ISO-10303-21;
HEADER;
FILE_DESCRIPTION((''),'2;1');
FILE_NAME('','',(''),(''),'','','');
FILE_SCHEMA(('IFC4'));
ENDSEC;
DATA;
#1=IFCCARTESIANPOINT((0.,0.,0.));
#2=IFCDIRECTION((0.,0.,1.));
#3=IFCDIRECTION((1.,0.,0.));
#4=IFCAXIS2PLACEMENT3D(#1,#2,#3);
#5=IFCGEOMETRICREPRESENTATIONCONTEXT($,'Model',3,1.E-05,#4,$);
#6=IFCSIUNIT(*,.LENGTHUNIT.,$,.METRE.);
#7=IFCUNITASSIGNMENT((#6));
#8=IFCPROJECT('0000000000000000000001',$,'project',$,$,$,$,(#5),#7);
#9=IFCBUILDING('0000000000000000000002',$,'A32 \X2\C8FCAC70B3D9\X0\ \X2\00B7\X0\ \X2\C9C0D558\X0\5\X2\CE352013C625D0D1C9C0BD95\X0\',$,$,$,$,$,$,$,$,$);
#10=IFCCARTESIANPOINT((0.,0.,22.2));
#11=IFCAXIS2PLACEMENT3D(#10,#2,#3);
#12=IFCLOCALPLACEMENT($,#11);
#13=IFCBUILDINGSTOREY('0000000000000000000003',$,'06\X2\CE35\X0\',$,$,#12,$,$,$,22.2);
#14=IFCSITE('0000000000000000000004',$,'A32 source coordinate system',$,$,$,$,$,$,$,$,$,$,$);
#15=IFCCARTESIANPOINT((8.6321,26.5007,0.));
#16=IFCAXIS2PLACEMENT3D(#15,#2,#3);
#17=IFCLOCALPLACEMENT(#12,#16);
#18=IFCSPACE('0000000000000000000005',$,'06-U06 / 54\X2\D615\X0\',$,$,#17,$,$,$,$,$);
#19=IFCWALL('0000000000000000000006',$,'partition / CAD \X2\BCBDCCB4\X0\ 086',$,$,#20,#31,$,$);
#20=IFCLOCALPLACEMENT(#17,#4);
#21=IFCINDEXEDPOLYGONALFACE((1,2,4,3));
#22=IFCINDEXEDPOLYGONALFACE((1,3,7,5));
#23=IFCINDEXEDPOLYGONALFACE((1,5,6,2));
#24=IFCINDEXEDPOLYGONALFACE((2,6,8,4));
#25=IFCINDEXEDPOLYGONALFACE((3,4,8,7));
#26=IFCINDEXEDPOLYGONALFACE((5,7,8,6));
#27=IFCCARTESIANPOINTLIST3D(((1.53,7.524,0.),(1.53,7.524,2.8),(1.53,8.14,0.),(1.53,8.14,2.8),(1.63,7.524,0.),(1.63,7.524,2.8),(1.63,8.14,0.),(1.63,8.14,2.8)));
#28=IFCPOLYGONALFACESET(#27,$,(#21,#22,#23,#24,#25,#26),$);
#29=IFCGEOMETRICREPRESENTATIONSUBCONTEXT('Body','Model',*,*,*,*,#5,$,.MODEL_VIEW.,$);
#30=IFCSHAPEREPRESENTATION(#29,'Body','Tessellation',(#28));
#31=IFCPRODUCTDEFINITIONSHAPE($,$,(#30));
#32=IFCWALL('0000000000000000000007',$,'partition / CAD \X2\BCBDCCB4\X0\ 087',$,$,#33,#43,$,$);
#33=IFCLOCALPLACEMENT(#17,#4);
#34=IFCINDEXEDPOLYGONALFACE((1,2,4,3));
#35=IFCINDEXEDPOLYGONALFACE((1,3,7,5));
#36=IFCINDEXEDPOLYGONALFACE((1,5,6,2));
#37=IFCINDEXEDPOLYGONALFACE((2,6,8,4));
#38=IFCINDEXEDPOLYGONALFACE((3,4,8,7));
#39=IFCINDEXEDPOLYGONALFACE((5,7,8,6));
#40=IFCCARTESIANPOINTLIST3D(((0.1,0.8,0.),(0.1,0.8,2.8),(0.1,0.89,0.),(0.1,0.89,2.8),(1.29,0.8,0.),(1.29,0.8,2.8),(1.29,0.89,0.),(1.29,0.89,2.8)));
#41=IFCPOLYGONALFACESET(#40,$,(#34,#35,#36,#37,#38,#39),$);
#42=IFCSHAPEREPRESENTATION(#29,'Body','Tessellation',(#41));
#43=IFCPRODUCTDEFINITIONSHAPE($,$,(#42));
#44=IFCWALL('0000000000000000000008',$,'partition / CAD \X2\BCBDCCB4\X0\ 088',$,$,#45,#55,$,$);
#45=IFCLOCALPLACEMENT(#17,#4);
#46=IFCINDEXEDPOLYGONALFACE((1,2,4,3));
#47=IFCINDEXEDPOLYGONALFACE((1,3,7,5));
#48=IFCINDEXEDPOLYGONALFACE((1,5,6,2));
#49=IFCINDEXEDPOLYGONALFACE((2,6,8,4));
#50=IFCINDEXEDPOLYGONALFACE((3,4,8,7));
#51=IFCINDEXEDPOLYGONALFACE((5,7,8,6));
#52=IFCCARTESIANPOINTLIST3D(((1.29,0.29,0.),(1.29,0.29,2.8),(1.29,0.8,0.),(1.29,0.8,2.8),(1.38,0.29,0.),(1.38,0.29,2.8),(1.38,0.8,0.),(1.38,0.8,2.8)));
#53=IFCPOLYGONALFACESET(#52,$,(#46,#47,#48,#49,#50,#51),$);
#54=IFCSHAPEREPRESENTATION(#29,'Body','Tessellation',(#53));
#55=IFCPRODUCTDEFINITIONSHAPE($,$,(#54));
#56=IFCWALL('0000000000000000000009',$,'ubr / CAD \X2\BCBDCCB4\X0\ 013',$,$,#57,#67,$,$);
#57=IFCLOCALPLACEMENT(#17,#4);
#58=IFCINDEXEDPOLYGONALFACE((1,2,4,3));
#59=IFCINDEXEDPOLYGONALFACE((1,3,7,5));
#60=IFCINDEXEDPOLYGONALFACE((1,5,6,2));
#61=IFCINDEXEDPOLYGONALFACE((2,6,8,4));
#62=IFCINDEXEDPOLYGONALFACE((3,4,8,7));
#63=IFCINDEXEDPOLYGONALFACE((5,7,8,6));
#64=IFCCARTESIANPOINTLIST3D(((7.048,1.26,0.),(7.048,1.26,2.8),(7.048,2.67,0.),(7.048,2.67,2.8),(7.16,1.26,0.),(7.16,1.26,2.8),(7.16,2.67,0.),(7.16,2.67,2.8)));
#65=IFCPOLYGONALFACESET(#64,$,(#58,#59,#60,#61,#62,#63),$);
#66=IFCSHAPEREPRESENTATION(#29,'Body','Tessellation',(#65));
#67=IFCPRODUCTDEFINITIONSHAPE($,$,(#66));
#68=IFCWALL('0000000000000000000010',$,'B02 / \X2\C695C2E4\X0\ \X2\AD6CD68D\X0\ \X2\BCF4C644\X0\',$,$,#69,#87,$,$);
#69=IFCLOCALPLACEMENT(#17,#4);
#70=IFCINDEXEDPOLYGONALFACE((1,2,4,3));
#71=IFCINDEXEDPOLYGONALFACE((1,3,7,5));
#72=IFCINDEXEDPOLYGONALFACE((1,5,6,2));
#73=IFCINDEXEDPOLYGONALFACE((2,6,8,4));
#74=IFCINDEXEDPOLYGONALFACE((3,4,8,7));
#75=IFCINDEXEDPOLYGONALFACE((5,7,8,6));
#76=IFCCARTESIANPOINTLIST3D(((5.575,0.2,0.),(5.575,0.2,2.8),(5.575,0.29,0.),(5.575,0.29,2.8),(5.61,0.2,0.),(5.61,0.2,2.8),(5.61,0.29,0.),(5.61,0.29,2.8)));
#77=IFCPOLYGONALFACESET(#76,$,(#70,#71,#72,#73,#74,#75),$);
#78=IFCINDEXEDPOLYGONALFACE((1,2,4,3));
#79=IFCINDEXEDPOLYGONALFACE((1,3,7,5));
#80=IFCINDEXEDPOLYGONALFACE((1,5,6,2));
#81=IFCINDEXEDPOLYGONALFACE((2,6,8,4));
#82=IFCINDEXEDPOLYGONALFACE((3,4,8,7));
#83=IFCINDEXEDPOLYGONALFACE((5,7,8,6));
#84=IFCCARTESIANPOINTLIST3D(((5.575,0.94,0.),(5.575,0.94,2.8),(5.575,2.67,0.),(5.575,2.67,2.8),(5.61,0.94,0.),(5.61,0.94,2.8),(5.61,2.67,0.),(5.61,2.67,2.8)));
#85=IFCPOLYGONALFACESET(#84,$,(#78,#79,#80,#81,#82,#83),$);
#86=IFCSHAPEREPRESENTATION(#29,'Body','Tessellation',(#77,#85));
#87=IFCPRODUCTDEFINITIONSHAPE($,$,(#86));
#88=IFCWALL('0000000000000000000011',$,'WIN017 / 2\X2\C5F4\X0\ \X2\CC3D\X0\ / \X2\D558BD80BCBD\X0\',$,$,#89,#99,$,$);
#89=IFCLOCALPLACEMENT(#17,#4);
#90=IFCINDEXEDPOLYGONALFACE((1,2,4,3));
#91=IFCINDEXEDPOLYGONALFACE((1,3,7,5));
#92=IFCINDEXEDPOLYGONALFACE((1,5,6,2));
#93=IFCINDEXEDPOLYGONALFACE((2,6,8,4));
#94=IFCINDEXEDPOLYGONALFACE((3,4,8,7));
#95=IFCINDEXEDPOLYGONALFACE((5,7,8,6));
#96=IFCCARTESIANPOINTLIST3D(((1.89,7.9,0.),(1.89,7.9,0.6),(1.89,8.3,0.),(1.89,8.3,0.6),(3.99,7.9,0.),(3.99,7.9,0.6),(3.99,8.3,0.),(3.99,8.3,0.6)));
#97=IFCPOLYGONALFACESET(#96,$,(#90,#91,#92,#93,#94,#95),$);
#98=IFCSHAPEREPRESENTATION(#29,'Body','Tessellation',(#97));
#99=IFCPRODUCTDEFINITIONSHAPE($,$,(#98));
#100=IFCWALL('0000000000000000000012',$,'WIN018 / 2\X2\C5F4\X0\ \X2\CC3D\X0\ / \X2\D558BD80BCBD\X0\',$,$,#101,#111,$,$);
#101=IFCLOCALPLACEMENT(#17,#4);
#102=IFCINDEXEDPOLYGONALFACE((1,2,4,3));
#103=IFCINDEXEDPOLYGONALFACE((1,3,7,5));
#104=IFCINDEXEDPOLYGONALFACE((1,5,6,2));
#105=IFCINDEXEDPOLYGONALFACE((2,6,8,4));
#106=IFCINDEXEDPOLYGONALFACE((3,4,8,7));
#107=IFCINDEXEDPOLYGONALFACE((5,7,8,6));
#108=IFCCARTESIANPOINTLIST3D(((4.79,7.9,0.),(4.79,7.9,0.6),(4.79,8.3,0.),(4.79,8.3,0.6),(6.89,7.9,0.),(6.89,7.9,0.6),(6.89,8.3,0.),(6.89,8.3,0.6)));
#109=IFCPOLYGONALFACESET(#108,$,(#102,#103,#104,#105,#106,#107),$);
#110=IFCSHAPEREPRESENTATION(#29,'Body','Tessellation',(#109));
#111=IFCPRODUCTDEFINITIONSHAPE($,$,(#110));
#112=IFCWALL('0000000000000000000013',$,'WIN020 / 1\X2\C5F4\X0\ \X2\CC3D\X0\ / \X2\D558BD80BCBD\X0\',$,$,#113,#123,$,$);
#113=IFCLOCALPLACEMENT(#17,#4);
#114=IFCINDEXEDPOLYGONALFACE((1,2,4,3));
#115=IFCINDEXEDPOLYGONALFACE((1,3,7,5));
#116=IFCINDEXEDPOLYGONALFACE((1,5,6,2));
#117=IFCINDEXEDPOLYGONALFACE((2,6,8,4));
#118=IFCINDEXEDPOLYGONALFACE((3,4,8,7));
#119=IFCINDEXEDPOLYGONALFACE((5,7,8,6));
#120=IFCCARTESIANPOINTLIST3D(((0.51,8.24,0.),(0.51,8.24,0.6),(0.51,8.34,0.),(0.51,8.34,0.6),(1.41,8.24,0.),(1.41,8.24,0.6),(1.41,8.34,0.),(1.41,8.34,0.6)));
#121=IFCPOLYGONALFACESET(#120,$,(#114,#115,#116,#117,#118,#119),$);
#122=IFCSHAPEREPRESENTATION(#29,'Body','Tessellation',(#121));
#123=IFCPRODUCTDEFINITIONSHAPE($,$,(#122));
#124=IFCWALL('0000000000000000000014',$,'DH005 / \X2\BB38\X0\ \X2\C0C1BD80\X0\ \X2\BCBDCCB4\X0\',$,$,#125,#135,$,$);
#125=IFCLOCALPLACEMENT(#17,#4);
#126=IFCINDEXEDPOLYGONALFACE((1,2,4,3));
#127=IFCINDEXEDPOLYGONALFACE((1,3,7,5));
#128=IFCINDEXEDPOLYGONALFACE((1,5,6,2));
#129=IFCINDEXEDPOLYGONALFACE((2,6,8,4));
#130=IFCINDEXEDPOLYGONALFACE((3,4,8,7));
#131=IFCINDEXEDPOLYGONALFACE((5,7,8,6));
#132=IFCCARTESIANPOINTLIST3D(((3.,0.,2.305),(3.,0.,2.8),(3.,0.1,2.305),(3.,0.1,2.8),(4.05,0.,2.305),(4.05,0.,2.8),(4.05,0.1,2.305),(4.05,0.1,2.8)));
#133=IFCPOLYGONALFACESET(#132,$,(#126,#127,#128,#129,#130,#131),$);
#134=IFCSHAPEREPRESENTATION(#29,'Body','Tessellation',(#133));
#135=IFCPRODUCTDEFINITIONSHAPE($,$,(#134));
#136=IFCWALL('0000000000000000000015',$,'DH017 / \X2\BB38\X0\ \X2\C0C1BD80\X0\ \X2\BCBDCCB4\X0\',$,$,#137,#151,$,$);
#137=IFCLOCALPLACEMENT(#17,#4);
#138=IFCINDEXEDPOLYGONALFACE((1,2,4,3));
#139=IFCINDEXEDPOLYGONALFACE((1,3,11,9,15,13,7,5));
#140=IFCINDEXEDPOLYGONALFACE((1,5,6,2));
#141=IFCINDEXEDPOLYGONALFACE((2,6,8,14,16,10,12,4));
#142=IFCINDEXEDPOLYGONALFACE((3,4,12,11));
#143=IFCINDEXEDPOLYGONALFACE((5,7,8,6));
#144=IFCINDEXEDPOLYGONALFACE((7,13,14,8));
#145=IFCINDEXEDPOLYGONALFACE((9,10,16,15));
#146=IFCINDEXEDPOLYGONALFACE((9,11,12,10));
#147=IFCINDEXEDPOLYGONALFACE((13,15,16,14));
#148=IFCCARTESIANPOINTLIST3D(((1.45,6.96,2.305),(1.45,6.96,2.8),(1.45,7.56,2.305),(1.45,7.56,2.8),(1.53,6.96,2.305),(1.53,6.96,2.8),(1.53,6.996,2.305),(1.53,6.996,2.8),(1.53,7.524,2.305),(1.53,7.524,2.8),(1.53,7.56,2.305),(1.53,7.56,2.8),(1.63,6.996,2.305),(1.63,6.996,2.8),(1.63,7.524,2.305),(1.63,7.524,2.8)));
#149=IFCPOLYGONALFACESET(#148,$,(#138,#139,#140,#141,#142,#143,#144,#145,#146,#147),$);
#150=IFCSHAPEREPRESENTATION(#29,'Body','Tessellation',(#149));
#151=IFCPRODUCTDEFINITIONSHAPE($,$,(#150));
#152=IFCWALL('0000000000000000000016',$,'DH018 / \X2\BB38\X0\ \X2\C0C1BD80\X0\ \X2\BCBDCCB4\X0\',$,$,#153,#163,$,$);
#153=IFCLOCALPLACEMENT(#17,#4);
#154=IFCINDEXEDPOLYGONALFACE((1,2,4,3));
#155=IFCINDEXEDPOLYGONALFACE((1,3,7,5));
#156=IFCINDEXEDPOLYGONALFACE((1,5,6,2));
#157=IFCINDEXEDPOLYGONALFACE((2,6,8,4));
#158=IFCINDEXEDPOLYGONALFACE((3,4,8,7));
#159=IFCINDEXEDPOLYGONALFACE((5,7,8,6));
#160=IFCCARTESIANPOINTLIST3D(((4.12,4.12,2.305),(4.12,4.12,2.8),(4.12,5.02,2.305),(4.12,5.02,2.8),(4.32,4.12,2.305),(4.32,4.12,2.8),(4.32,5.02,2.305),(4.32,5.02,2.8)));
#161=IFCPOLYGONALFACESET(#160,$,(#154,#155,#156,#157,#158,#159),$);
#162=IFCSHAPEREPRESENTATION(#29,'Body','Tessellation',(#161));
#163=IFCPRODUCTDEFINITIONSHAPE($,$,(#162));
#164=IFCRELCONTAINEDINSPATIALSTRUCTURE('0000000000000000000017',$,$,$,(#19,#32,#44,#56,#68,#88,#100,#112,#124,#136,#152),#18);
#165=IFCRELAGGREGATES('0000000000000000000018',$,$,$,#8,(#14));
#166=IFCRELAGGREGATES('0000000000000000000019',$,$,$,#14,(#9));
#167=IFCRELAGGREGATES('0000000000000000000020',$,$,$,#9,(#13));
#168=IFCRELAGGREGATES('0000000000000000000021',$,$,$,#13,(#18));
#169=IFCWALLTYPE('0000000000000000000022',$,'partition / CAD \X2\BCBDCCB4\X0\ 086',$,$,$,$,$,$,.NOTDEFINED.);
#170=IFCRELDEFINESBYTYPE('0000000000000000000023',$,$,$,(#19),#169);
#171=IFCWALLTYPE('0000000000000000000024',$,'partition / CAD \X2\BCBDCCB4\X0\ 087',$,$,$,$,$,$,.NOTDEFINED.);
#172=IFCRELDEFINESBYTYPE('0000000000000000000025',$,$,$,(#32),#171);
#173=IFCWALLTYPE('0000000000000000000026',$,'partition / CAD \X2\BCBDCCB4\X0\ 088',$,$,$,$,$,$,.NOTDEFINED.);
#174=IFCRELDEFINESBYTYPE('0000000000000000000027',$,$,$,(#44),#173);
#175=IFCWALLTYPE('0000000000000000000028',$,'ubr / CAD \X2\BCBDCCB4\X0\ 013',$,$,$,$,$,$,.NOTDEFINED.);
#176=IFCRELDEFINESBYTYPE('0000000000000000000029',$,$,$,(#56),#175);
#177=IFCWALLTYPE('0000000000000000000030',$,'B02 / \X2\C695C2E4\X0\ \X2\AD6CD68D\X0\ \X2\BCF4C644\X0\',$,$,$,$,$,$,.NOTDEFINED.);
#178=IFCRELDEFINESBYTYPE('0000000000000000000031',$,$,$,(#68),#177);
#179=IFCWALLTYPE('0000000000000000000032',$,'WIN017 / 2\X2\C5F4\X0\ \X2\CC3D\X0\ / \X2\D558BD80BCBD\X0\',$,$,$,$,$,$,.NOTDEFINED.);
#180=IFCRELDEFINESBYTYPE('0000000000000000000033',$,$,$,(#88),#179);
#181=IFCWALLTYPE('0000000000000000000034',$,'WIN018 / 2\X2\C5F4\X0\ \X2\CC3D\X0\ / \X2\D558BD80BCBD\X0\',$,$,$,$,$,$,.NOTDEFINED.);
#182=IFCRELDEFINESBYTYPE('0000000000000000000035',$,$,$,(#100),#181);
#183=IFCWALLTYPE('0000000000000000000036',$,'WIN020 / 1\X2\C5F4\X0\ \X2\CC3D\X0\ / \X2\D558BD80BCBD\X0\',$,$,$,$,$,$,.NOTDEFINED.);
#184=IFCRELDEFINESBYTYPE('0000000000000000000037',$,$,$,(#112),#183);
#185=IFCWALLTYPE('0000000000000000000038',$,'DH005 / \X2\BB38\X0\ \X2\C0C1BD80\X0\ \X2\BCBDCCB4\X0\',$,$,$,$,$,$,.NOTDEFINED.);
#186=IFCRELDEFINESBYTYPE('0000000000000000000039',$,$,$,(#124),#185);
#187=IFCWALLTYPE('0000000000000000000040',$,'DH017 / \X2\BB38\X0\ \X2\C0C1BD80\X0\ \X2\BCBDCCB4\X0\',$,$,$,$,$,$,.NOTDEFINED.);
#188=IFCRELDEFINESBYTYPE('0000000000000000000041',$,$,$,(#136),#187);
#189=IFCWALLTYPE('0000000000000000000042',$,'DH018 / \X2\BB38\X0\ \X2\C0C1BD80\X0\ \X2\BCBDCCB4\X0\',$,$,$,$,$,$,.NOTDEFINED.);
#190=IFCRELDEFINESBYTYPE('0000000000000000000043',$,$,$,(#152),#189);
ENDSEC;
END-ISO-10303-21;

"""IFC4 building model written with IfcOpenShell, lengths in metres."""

from ifc_helpers import new_model, si_unit, frame, origin, origin_with_axes, place, context, subcontext, project, spatial, polyline, outline, extrude, source, transform, mapped, type_object, type_shapes, element, save


model = new_model("IFC4")

# Units and contexts
model_context = context("Model", 3, precision=1e-05, world=origin_with_axes())
body_context = subcontext(model_context, "Body", "Model", "MODEL_VIEW")
ifc_project = project(units=[si_unit("LENGTHUNIT", "METRE")], contexts=[model_context])

# Site, building, storey, space
site = spatial("IfcSite", under=ifc_project, Name="A32 source coordinate system")
building = spatial("IfcBuilding", under=site, Name="A32 주거동 · 지하5층–옥탑지붕")
storey_placement = place(None, frame((0.0, 0.0, 22.2), z_axis=(0.0, 0.0, 1.0), x_axis=(1.0, 0.0, 0.0)))
storey = spatial("IfcBuildingStorey", under=building, at=storey_placement, Name="06층", Elevation=22.2)
space_placement = place(storey_placement, frame((8.6321, 26.5007, 0.0), z_axis=(0.0, 0.0, 1.0), x_axis=(1.0, 0.0, 0.0)))
space = spatial("IfcSpace", under=storey, at=space_placement, Name="06-U06 / 54형")

# Walls
wall_type_1 = type_object("IfcWallType", Name="partition / CAD 벽체 086", PredefinedType="NOTDEFINED")
shared_shape_1 = source(origin(), body_context, "Body", "SweptSolid", [
    extrude(outline(polyline([(1.53, 7.524), (1.53, 8.14), (1.63, 8.14), (1.63, 7.524), (1.53, 7.524)])), origin(), (0.0, 0.0, 1.0), 2.8),
])
type_shapes(wall_type_1, [shared_shape_1])
wall_1_placement = place(space_placement, origin_with_axes())
element("IfcWall", 1, at=wall_1_placement, inside=space, type_object=wall_type_1, Name="partition / CAD 벽체 086", context=body_context, shape_type="MappedRepresentation", body=[
    mapped(shared_shape_1, transform((0.0, 0.0, 0.0), scale=1.0)),
])
wall_type_2 = type_object("IfcWallType", Name="partition / CAD 벽체 087", PredefinedType="NOTDEFINED")
shared_shape_2 = source(origin(), body_context, "Body", "SweptSolid", [
    extrude(outline(polyline([(1.29, 0.8), (0.1, 0.8), (0.1, 0.89), (1.29, 0.89), (1.29, 0.8)])), origin(), (0.0, 0.0, 1.0), 2.8),
])
type_shapes(wall_type_2, [shared_shape_2])
wall_2_placement = place(space_placement, origin_with_axes())
element("IfcWall", 2, at=wall_2_placement, inside=space, type_object=wall_type_2, Name="partition / CAD 벽체 087", context=body_context, shape_type="MappedRepresentation", body=[
    mapped(shared_shape_2, transform((0.0, 0.0, 0.0), scale=1.0)),
])
wall_type_3 = type_object("IfcWallType", Name="partition / CAD 벽체 088", PredefinedType="NOTDEFINED")
shared_shape_3 = source(origin(), body_context, "Body", "SweptSolid", [
    extrude(outline(polyline([(1.29, 0.29), (1.29, 0.8), (1.38, 0.8), (1.38, 0.29), (1.29, 0.29)])), origin(), (0.0, 0.0, 1.0), 2.8),
])
type_shapes(wall_type_3, [shared_shape_3])
wall_3_placement = place(space_placement, origin_with_axes())
element("IfcWall", 3, at=wall_3_placement, inside=space, type_object=wall_type_3, Name="partition / CAD 벽체 088", context=body_context, shape_type="MappedRepresentation", body=[
    mapped(shared_shape_3, transform((0.0, 0.0, 0.0), scale=1.0)),
])
wall_type_4 = type_object("IfcWallType", Name="ubr / CAD 벽체 013", PredefinedType="NOTDEFINED")
shared_shape_4 = source(origin(), body_context, "Body", "SweptSolid", [
    extrude(outline(polyline([(7.16, 1.26), (7.048, 1.26), (7.048, 2.67), (7.16, 2.67), (7.16, 1.26)])), origin(), (0.0, 0.0, 1.0), 2.8),
])
type_shapes(wall_type_4, [shared_shape_4])
wall_4_placement = place(space_placement, origin_with_axes())
element("IfcWall", 4, at=wall_4_placement, inside=space, type_object=wall_type_4, Name="ubr / CAD 벽체 013", context=body_context, shape_type="MappedRepresentation", body=[
    mapped(shared_shape_4, transform((0.0, 0.0, 0.0), scale=1.0)),
])
wall_type_5 = type_object("IfcWallType", Name="B02 / 욕실 구획 보완", PredefinedType="NOTDEFINED")
shared_shape_5 = source(origin(), body_context, "Body", "SweptSolid", [
    extrude(outline(polyline([(5.575, 0.2), (5.575, 0.29), (5.61, 0.29), (5.61, 0.2), (5.575, 0.2)])), origin(), (0.0, 0.0, 1.0), 2.8),
    extrude(outline(polyline([(5.575, 0.94), (5.575, 2.67), (5.61, 2.67), (5.61, 0.94), (5.575, 0.94)])), origin(), (0.0, 0.0, 1.0), 2.8),
])
type_shapes(wall_type_5, [shared_shape_5])
wall_5_placement = place(space_placement, origin_with_axes())
element("IfcWall", 5, at=wall_5_placement, inside=space, type_object=wall_type_5, Name="B02 / 욕실 구획 보완", context=body_context, shape_type="MappedRepresentation", body=[
    mapped(shared_shape_5, transform((0.0, 0.0, 0.0), scale=1.0)),
])
wall_type_6 = type_object("IfcWallType", Name="WIN017 / 2열 창 / 하부벽", PredefinedType="NOTDEFINED")
shared_shape_6 = source(origin(), body_context, "Body", "SweptSolid", [
    extrude(outline(polyline([(3.99, 8.3), (3.99, 7.9), (1.89, 7.9), (1.89, 8.3), (3.99, 8.3)])), origin(), (0.0, 0.0, 1.0), 0.6),
])
type_shapes(wall_type_6, [shared_shape_6])
wall_6_placement = place(space_placement, origin_with_axes())
element("IfcWall", 6, at=wall_6_placement, inside=space, type_object=wall_type_6, Name="WIN017 / 2열 창 / 하부벽", context=body_context, shape_type="MappedRepresentation", body=[
    mapped(shared_shape_6, transform((0.0, 0.0, 0.0), scale=1.0)),
])
wall_type_7 = type_object("IfcWallType", Name="WIN018 / 2열 창 / 하부벽", PredefinedType="NOTDEFINED")
shared_shape_7 = source(origin(), body_context, "Body", "SweptSolid", [
    extrude(outline(polyline([(6.89, 8.3), (6.89, 7.9), (4.79, 7.9), (4.79, 8.3), (6.89, 8.3)])), origin(), (0.0, 0.0, 1.0), 0.6),
])
type_shapes(wall_type_7, [shared_shape_7])
wall_7_placement = place(space_placement, origin_with_axes())
element("IfcWall", 7, at=wall_7_placement, inside=space, type_object=wall_type_7, Name="WIN018 / 2열 창 / 하부벽", context=body_context, shape_type="MappedRepresentation", body=[
    mapped(shared_shape_7, transform((0.0, 0.0, 0.0), scale=1.0)),
])
wall_type_8 = type_object("IfcWallType", Name="WIN020 / 1열 창 / 하부벽", PredefinedType="NOTDEFINED")
shared_shape_8 = source(origin(), body_context, "Body", "SweptSolid", [
    extrude(outline(polyline([(1.41, 8.34), (1.41, 8.24), (0.51, 8.24), (0.51, 8.34), (1.41, 8.34)])), origin(), (0.0, 0.0, 1.0), 0.6),
])
type_shapes(wall_type_8, [shared_shape_8])
wall_8_placement = place(space_placement, origin_with_axes())
element("IfcWall", 8, at=wall_8_placement, inside=space, type_object=wall_type_8, Name="WIN020 / 1열 창 / 하부벽", context=body_context, shape_type="MappedRepresentation", body=[
    mapped(shared_shape_8, transform((0.0, 0.0, 0.0), scale=1.0)),
])
wall_type_9 = type_object("IfcWallType", Name="DH005 / 문 상부 벽체", PredefinedType="NOTDEFINED")
shared_shape_9 = source(origin(), body_context, "Body", "SweptSolid", [
    extrude(outline(polyline([(4.05, 0.0), (3.0, 0.0), (3.0, 0.1), (4.05, 0.1), (4.05, 0.0)])), frame((0.0, 0.0, 2.305)), (0.0, 0.0, 1.0), 0.495),
])
type_shapes(wall_type_9, [shared_shape_9])
wall_9_placement = place(space_placement, origin_with_axes())
element("IfcWall", 9, at=wall_9_placement, inside=space, type_object=wall_type_9, Name="DH005 / 문 상부 벽체", context=body_context, shape_type="MappedRepresentation", body=[
    mapped(shared_shape_9, transform((0.0, 0.0, 0.0), scale=1.0)),
])
wall_type_10 = type_object("IfcWallType", Name="DH017 / 문 상부 벽체", PredefinedType="NOTDEFINED")
shared_shape_10 = source(origin(), body_context, "Body", "SweptSolid", [
    extrude(outline(polyline([(1.63, 7.524), (1.63, 6.996), (1.53, 6.996), (1.53, 6.96), (1.45, 6.96), (1.45, 7.56), (1.53, 7.56), (1.53, 7.524), (1.63, 7.524)])), frame((0.0, 0.0, 2.305)), (0.0, 0.0, 1.0), 0.495),
])
type_shapes(wall_type_10, [shared_shape_10])
wall_10_placement = place(space_placement, origin_with_axes())
element("IfcWall", 10, at=wall_10_placement, inside=space, type_object=wall_type_10, Name="DH017 / 문 상부 벽체", context=body_context, shape_type="MappedRepresentation", body=[
    mapped(shared_shape_10, transform((0.0, 0.0, 0.0), scale=1.0)),
])
wall_type_11 = type_object("IfcWallType", Name="DH018 / 문 상부 벽체", PredefinedType="NOTDEFINED")
shared_shape_11 = source(origin(), body_context, "Body", "SweptSolid", [
    extrude(outline(polyline([(4.32, 4.12), (4.12, 4.12), (4.12, 5.02), (4.32, 5.02), (4.32, 4.12)])), frame((0.0, 0.0, 2.305)), (0.0, 0.0, 1.0), 0.495),
])
type_shapes(wall_type_11, [shared_shape_11])
wall_11_placement = place(space_placement, origin_with_axes())
element("IfcWall", 11, at=wall_11_placement, inside=space, type_object=wall_type_11, Name="DH018 / 문 상부 벽체", context=body_context, shape_type="MappedRepresentation", body=[
    mapped(shared_shape_11, transform((0.0, 0.0, 0.0), scale=1.0)),
])

save(model, "model.ifc")
